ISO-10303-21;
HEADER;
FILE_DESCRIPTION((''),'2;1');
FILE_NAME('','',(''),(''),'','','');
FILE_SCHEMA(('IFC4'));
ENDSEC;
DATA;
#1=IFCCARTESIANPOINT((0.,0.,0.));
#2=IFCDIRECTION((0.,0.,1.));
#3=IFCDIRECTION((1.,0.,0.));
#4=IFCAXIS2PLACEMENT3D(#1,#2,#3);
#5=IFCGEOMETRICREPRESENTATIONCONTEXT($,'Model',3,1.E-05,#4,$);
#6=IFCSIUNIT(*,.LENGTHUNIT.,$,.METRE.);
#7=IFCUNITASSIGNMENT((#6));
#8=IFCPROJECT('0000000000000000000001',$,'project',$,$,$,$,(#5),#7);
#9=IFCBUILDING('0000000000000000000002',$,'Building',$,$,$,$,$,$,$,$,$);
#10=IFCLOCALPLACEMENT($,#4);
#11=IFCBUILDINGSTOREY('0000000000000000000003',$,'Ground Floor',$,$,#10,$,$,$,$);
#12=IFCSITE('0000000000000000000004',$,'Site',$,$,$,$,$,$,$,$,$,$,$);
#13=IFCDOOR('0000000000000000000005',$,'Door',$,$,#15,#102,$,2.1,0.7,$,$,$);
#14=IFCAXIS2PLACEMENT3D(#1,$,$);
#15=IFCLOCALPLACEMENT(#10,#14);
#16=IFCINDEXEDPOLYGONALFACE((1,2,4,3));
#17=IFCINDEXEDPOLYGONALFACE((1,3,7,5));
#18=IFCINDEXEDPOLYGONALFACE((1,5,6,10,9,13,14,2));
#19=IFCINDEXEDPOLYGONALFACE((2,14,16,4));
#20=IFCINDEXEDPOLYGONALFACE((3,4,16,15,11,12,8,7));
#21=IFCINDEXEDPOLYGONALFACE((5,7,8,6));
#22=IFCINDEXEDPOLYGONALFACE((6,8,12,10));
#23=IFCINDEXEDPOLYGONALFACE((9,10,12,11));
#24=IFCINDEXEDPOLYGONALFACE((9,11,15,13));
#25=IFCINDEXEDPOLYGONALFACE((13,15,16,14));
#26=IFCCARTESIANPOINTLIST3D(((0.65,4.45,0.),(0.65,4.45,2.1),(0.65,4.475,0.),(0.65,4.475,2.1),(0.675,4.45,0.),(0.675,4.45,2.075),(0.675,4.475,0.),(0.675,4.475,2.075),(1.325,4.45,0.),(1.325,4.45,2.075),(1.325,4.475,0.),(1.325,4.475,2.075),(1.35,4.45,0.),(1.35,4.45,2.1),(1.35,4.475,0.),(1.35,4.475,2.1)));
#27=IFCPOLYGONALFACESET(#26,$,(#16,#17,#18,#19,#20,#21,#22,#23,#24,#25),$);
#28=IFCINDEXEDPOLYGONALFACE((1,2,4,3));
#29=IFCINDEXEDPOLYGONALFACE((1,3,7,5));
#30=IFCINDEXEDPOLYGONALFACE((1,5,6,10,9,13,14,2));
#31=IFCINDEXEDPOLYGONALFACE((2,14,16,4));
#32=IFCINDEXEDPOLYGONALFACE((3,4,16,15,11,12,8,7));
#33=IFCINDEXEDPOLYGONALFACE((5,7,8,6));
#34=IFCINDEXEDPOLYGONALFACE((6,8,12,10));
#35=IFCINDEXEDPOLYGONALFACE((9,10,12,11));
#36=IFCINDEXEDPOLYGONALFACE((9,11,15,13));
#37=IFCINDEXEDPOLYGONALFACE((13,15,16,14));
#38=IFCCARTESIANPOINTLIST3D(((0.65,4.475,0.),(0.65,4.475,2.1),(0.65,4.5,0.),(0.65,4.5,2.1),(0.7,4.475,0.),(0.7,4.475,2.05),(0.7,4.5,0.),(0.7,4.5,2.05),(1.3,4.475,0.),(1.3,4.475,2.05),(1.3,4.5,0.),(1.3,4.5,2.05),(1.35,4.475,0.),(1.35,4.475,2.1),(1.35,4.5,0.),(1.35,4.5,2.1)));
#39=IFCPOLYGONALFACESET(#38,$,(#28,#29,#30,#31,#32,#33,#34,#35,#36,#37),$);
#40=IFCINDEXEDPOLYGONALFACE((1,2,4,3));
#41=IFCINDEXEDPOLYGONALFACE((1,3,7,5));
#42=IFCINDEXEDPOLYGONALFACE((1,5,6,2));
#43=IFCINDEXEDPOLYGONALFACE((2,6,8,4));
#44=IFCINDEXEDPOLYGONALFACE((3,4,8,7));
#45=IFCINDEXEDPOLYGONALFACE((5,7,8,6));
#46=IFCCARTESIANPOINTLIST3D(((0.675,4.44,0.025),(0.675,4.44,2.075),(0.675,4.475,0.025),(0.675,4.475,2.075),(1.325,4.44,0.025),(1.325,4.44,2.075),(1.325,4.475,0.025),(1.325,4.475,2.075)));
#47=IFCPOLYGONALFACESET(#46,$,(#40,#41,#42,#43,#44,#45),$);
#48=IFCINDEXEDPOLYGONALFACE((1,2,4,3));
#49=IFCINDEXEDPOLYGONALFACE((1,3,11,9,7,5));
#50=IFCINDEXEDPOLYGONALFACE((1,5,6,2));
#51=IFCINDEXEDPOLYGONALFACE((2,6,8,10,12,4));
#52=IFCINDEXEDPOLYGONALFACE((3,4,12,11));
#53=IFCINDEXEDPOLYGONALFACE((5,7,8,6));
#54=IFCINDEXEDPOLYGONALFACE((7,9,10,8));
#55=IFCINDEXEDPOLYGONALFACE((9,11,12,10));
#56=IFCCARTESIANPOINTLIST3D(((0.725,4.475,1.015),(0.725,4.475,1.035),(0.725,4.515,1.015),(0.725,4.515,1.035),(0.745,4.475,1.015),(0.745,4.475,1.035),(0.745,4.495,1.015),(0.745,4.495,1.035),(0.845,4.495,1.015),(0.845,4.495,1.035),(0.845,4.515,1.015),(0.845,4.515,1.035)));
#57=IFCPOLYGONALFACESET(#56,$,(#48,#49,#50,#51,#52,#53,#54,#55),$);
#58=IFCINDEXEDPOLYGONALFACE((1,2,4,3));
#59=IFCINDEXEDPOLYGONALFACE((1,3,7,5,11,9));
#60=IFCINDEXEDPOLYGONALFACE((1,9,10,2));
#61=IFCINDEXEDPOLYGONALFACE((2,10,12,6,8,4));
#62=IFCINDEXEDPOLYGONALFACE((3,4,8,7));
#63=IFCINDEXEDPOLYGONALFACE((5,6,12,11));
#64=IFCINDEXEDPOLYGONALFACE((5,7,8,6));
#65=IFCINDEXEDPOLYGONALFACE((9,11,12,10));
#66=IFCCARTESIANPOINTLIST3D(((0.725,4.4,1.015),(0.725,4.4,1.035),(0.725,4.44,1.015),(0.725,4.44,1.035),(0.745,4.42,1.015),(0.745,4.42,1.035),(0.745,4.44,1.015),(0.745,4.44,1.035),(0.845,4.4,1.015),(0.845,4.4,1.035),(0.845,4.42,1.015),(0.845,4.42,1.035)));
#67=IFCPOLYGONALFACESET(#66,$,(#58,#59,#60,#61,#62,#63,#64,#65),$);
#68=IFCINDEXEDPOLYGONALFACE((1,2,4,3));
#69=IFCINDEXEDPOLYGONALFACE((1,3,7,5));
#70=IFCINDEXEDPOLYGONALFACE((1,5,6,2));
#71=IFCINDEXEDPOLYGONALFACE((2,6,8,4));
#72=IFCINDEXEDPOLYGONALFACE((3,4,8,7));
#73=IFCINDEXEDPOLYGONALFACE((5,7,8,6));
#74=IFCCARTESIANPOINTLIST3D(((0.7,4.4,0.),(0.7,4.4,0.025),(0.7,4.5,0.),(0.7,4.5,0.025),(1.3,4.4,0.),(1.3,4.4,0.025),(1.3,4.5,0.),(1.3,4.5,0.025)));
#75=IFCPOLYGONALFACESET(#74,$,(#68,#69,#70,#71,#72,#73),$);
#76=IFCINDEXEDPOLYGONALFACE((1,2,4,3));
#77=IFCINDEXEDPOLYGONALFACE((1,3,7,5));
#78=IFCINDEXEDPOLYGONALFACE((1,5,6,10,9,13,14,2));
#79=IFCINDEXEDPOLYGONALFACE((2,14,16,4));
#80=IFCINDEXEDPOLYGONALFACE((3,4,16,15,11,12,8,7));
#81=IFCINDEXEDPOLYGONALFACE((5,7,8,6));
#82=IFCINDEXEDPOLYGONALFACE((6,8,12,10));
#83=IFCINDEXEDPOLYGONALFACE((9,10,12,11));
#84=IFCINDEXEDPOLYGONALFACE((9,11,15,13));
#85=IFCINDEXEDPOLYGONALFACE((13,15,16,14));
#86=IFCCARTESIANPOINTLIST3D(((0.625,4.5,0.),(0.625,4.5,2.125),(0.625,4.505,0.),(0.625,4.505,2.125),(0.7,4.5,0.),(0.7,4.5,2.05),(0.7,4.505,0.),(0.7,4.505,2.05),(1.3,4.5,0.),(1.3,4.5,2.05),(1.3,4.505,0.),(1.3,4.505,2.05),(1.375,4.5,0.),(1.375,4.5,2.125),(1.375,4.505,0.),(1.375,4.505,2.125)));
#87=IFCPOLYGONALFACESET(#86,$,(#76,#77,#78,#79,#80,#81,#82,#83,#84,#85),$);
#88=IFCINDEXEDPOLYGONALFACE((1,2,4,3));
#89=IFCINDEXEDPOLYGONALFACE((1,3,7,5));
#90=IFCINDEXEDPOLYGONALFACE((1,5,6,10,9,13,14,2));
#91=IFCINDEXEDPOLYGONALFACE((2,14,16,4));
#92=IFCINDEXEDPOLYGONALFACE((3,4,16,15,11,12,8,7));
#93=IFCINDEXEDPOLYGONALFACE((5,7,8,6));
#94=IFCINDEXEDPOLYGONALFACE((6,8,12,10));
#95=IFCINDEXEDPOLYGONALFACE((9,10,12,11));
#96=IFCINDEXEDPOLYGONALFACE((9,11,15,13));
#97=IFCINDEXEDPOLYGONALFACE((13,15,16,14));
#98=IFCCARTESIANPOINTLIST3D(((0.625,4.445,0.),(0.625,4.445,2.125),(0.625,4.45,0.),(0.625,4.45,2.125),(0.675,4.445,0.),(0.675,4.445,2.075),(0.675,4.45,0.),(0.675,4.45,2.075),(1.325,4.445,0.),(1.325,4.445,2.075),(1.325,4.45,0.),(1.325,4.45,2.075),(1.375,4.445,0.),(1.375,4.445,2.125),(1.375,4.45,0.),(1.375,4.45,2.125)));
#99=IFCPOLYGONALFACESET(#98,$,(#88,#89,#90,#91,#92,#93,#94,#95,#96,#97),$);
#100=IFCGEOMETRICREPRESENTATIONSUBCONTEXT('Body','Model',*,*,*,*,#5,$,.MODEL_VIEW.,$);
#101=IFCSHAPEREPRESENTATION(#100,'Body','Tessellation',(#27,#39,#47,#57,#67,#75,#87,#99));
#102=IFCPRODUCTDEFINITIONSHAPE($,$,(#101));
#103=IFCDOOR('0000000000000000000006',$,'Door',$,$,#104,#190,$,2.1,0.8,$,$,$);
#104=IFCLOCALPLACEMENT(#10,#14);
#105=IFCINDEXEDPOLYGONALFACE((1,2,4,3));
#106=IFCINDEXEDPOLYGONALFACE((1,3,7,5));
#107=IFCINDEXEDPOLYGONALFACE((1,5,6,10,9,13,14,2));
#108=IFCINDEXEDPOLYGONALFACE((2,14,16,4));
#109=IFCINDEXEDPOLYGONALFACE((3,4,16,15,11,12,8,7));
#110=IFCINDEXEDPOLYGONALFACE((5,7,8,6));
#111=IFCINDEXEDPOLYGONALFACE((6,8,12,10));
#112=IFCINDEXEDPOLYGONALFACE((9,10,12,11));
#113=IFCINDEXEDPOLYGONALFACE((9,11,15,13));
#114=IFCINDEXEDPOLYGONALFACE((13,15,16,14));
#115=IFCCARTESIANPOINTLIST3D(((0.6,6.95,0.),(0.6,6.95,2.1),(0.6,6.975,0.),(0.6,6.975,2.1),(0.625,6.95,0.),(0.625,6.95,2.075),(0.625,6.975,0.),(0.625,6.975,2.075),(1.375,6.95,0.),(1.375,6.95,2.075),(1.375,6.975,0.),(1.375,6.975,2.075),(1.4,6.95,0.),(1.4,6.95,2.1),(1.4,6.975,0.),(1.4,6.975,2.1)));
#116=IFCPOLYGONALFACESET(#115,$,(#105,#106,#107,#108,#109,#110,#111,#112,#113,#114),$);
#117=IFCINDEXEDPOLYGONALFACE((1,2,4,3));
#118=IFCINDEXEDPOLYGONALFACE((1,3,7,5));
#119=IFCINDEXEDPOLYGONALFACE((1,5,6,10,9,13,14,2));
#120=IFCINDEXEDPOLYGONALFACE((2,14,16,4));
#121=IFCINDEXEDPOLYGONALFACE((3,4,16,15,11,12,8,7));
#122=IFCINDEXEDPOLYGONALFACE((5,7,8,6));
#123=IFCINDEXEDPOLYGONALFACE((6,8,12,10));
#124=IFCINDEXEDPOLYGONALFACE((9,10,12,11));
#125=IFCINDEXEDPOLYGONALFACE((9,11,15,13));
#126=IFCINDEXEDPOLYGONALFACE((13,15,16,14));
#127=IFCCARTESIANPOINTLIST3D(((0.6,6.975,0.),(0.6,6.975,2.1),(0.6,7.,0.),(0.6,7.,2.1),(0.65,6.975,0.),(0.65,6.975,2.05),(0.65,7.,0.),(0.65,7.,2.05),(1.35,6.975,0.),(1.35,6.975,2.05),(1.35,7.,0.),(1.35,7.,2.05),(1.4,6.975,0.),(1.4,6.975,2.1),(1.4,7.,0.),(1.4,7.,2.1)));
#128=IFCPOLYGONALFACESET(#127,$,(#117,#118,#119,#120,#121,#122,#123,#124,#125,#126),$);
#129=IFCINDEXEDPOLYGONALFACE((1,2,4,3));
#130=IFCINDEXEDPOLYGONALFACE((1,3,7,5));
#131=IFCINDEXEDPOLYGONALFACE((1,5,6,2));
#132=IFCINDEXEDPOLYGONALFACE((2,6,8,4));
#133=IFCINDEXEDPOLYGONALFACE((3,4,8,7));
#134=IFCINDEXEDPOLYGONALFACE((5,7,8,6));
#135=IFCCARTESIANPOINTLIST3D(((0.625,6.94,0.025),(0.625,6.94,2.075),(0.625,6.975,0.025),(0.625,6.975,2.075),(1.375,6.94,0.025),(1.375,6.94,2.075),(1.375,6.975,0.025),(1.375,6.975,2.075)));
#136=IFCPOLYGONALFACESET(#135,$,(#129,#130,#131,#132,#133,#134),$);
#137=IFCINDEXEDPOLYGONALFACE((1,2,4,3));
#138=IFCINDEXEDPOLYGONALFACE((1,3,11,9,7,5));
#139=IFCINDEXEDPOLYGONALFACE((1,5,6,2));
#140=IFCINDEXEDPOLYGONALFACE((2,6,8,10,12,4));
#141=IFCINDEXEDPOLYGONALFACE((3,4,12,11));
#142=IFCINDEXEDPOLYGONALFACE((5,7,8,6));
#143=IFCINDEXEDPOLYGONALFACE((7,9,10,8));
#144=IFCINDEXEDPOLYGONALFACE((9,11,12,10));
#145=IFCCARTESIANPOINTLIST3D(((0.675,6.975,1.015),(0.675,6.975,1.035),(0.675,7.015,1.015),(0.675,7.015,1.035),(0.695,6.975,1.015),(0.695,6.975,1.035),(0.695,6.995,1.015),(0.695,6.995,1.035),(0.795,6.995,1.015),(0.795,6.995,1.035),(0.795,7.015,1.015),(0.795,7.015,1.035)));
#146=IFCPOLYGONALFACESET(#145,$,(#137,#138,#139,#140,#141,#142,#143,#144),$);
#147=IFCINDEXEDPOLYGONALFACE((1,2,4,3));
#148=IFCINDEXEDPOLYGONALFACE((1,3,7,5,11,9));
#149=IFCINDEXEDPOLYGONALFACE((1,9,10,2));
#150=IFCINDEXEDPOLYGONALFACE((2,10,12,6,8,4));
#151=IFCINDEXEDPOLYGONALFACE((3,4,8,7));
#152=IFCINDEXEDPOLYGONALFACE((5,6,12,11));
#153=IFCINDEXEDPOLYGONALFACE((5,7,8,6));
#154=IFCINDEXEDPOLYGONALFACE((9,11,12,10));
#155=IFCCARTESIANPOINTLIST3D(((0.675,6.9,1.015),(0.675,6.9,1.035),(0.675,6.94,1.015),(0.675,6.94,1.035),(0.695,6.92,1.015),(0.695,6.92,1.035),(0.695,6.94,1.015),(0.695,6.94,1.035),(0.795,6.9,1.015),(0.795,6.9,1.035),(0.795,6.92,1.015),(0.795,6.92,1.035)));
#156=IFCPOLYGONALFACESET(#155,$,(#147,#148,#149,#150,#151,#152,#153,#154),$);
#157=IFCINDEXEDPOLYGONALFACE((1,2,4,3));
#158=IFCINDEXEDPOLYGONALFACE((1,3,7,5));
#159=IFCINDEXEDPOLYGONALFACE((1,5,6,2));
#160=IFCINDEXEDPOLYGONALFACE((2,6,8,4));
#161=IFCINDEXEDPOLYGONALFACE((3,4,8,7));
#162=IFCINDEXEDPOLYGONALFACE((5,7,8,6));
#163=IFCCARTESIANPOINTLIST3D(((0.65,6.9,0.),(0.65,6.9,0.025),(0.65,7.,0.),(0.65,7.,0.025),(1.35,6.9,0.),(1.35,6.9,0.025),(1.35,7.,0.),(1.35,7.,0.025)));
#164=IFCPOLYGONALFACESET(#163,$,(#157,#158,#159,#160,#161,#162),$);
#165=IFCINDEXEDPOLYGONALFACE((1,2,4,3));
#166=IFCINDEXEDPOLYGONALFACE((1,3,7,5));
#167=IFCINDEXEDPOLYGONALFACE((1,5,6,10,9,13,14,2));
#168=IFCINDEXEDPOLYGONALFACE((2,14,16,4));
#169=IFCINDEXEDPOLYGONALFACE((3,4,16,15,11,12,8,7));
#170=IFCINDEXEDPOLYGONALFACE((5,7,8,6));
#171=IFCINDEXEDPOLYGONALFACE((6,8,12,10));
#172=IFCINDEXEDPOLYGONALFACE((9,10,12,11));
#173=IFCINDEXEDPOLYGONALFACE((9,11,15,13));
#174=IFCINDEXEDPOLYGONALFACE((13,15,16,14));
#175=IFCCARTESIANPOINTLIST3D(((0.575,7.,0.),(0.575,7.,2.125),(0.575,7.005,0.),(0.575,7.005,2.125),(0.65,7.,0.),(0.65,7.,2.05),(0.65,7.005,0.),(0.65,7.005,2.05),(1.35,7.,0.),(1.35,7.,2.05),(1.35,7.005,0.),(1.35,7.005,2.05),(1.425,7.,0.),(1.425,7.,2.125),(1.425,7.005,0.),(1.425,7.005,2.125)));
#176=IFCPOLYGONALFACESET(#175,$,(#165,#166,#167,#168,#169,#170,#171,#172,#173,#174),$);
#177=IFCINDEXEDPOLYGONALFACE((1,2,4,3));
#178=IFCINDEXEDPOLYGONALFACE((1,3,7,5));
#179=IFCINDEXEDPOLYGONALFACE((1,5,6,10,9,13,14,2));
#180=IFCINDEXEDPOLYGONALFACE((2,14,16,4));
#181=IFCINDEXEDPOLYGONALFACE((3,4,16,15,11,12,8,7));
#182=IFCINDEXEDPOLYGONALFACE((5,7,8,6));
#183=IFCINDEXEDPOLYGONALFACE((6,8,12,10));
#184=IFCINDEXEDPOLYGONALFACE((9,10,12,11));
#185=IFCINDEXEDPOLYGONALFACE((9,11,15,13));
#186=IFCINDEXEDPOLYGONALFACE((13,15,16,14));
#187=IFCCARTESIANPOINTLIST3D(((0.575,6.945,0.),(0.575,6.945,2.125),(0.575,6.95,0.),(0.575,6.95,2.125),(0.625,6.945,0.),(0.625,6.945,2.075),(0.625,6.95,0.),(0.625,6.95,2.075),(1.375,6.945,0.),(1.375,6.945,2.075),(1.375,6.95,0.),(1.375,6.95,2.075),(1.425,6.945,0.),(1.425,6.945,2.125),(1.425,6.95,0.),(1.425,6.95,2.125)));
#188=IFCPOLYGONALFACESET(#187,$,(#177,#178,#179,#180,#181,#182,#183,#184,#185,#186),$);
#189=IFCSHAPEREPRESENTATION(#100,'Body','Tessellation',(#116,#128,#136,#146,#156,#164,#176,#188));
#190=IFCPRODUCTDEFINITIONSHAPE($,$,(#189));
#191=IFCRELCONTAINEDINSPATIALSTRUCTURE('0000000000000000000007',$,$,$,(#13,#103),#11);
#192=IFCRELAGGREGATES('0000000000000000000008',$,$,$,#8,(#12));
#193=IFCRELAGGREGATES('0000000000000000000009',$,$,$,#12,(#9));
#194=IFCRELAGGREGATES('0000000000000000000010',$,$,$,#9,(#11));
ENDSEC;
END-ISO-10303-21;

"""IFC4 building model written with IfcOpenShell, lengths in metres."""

from ifc_helpers import new_model, si_unit, frame, origin_with_axes, place, context, subcontext, project, spatial, line, indexed_curve, outline, extrude, element, save


model = new_model("IFC4")

# Units and contexts
model_context = context("Model", 3, precision=1e-05, world=origin_with_axes())
body_context = subcontext(model_context, "Body", "Model", "MODEL_VIEW")
ifc_project = project(units=[si_unit("LENGTHUNIT", "METRE")], contexts=[model_context])

# Site, building, storey
site = spatial("IfcSite", under=ifc_project, Name="Site")
building = spatial("IfcBuilding", under=site, Name="Building")
storey_placement = place(None, origin_with_axes())
storey = spatial("IfcBuildingStorey", under=building, at=storey_placement, Name="Ground Floor")

# Doors
door_1_placement = place(storey_placement, frame((1.35, 4.5, 0.0), z_axis=(0.0, 0.0, 1.0), x_axis=(-1.0, 0.0, 0.0)))
element("IfcDoor", 1, at=door_1_placement, inside=storey, Name="Door", OverallHeight=2.1, OverallWidth=0.7, context=body_context, shape_type="SweptSolid", body=[
    extrude(outline(indexed_curve([(0.0, 0.0), (0.0, 2.1), (0.7, 2.1), (0.7, 0.0), (0.675, 0.0), (0.675, 2.075), (0.025, 2.075), (0.025, 0.0)], segments=[line(1, 2, 3, 4, 5, 6, 7, 8, 1)])), frame((0.0, 0.025, 0.0), z_axis=(0.0, -1.0, 0.0), x_axis=(1.0, 0.0, 0.0)), (0.0, 0.0, -1.0), 0.025),
    extrude(outline(indexed_curve([(0.0, 0.0), (0.0, 2.1), (0.7, 2.1), (0.7, 0.0), (0.65, 0.0), (0.65, 2.05), (0.05, 2.05), (0.05, 0.0)], segments=[line(1, 2, 3, 4, 5, 6, 7, 8, 1)])), frame((0.0, 0.0, 0.0), z_axis=(0.0, -1.0, 0.0), x_axis=(1.0, 0.0, 0.0)), (0.0, 0.0, -1.0), 0.025),
    extrude(outline(indexed_curve([(0.0, 0.0), (0.65, 0.0), (0.65, 0.035), (0.0, 0.035)], segments=[line(1, 2, 3, 4, 1)])), frame((0.025, 0.025, 0.025), z_axis=(0.0, 0.0, 1.0), x_axis=(1.0, 0.0, 0.0)), (0.0, 0.0, 1.0), 2.05),
    extrude(outline(indexed_curve([(0.0, 0.0), (0.0, -0.04), (-0.12, -0.04), (-0.12, -0.02), (-0.02, -0.02), (-0.02, 0.0)], segments=[line(1, 2, 3, 4, 5, 6, 1)])), frame((0.625, 0.025, 1.015), z_axis=(0.0, 0.0, 1.0), x_axis=(1.0, 0.0, 0.0)), (0.0, 0.0, 1.0), 0.02),
    extrude(outline(indexed_curve([(0.0, 0.0), (0.0, 0.04), (-0.12, 0.04), (-0.12, 0.02), (-0.02, 0.02), (-0.02, 0.0)], segments=[line(1, 2, 3, 4, 5, 6, 1)])), frame((0.625, 0.06, 1.015), z_axis=(0.0, 0.0, 1.0), x_axis=(1.0, 0.0, 0.0)), (0.0, 0.0, 1.0), 0.02),
    extrude(outline(indexed_curve([(0.0, 0.0), (0.6, 0.0), (0.6, 0.1), (0.0, 0.1)], segments=[line(1, 2, 3, 4, 1)])), frame((0.05, 0.0, 0.0), z_axis=(0.0, 0.0, 1.0), x_axis=(1.0, 0.0, 0.0)), (0.0, 0.0, 1.0), 0.025),
    extrude(outline(indexed_curve([(0.0, 0.0), (0.0, 2.125), (0.75, 2.125), (0.75, 0.0), (0.675, 0.0), (0.675, 2.05), (0.075, 2.05), (0.075, 0.0)], segments=[line(1, 2, 3, 4, 5, 6, 7, 8, 1)])), frame((-0.025, -0.005, 0.0), z_axis=(0.0, -1.0, 0.0), x_axis=(1.0, 0.0, 0.0)), (0.0, 0.0, -1.0), 0.005),
    extrude(outline(indexed_curve([(0.0, 0.0), (0.0, 2.125), (0.75, 2.125), (0.75, 0.0), (0.7, 0.0), (0.7, 2.075), (0.05, 2.075), (0.05, 0.0)], segments=[line(1, 2, 3, 4, 5, 6, 7, 8, 1)])), frame((-0.025, 0.05, 0.0), z_axis=(0.0, -1.0, 0.0), x_axis=(1.0, 0.0, 0.0)), (0.0, 0.0, -1.0), 0.005),
])
door_2_placement = place(storey_placement, frame((1.4, 7.0, 0.0), z_axis=(0.0, 0.0, 1.0), x_axis=(-1.0, 0.0, 0.0)))
element("IfcDoor", 2, at=door_2_placement, inside=storey, Name="Door", OverallHeight=2.1, OverallWidth=0.8, context=body_context, shape_type="SweptSolid", body=[
    extrude(outline(indexed_curve([(0.0, 0.0), (0.0, 2.1), (0.8, 2.1), (0.8, 0.0), (0.775, 0.0), (0.775, 2.075), (0.025, 2.075), (0.025, 0.0)], segments=[line(1, 2, 3, 4, 5, 6, 7, 8, 1)])), frame((0.0, 0.025, 0.0), z_axis=(0.0, -1.0, 0.0), x_axis=(1.0, 0.0, 0.0)), (0.0, 0.0, -1.0), 0.025),
    extrude(outline(indexed_curve([(0.0, 0.0), (0.0, 2.1), (0.8, 2.1), (0.8, 0.0), (0.75, 0.0), (0.75, 2.05), (0.05, 2.05), (0.05, 0.0)], segments=[line(1, 2, 3, 4, 5, 6, 7, 8, 1)])), frame((0.0, 0.0, 0.0), z_axis=(0.0, -1.0, 0.0), x_axis=(1.0, 0.0, 0.0)), (0.0, 0.0, -1.0), 0.025),
    extrude(outline(indexed_curve([(0.0, 0.0), (0.75, 0.0), (0.75, 0.035), (0.0, 0.035)], segments=[line(1, 2, 3, 4, 1)])), frame((0.025, 0.025, 0.025), z_axis=(0.0, 0.0, 1.0), x_axis=(1.0, 0.0, 0.0)), (0.0, 0.0, 1.0), 2.05),
    extrude(outline(indexed_curve([(0.0, 0.0), (0.0, -0.04), (-0.12, -0.04), (-0.12, -0.02), (-0.02, -0.02), (-0.02, 0.0)], segments=[line(1, 2, 3, 4, 5, 6, 1)])), frame((0.725, 0.025, 1.015), z_axis=(0.0, 0.0, 1.0), x_axis=(1.0, 0.0, 0.0)), (0.0, 0.0, 1.0), 0.02),
    extrude(outline(indexed_curve([(0.0, 0.0), (0.0, 0.04), (-0.12, 0.04), (-0.12, 0.02), (-0.02, 0.02), (-0.02, 0.0)], segments=[line(1, 2, 3, 4, 5, 6, 1)])), frame((0.725, 0.06, 1.015), z_axis=(0.0, 0.0, 1.0), x_axis=(1.0, 0.0, 0.0)), (0.0, 0.0, 1.0), 0.02),
    extrude(outline(indexed_curve([(0.0, 0.0), (0.7, 0.0), (0.7, 0.1), (0.0, 0.1)], segments=[line(1, 2, 3, 4, 1)])), frame((0.05, 0.0, 0.0), z_axis=(0.0, 0.0, 1.0), x_axis=(1.0, 0.0, 0.0)), (0.0, 0.0, 1.0), 0.025),
    extrude(outline(indexed_curve([(0.0, 0.0), (0.0, 2.125), (0.85, 2.125), (0.85, 0.0), (0.775, 0.0), (0.775, 2.05), (0.075, 2.05), (0.075, 0.0)], segments=[line(1, 2, 3, 4, 5, 6, 7, 8, 1)])), frame((-0.025, -0.005, 0.0), z_axis=(0.0, -1.0, 0.0), x_axis=(1.0, 0.0, 0.0)), (0.0, 0.0, -1.0), 0.005),
    extrude(outline(indexed_curve([(0.0, 0.0), (0.0, 2.125), (0.85, 2.125), (0.85, 0.0), (0.8, 0.0), (0.8, 2.075), (0.05, 2.075), (0.05, 0.0)], segments=[line(1, 2, 3, 4, 5, 6, 7, 8, 1)])), frame((-0.025, 0.05, 0.0), z_axis=(0.0, -1.0, 0.0), x_axis=(1.0, 0.0, 0.0)), (0.0, 0.0, -1.0), 0.005),
])

save(model, "model.ifc")
